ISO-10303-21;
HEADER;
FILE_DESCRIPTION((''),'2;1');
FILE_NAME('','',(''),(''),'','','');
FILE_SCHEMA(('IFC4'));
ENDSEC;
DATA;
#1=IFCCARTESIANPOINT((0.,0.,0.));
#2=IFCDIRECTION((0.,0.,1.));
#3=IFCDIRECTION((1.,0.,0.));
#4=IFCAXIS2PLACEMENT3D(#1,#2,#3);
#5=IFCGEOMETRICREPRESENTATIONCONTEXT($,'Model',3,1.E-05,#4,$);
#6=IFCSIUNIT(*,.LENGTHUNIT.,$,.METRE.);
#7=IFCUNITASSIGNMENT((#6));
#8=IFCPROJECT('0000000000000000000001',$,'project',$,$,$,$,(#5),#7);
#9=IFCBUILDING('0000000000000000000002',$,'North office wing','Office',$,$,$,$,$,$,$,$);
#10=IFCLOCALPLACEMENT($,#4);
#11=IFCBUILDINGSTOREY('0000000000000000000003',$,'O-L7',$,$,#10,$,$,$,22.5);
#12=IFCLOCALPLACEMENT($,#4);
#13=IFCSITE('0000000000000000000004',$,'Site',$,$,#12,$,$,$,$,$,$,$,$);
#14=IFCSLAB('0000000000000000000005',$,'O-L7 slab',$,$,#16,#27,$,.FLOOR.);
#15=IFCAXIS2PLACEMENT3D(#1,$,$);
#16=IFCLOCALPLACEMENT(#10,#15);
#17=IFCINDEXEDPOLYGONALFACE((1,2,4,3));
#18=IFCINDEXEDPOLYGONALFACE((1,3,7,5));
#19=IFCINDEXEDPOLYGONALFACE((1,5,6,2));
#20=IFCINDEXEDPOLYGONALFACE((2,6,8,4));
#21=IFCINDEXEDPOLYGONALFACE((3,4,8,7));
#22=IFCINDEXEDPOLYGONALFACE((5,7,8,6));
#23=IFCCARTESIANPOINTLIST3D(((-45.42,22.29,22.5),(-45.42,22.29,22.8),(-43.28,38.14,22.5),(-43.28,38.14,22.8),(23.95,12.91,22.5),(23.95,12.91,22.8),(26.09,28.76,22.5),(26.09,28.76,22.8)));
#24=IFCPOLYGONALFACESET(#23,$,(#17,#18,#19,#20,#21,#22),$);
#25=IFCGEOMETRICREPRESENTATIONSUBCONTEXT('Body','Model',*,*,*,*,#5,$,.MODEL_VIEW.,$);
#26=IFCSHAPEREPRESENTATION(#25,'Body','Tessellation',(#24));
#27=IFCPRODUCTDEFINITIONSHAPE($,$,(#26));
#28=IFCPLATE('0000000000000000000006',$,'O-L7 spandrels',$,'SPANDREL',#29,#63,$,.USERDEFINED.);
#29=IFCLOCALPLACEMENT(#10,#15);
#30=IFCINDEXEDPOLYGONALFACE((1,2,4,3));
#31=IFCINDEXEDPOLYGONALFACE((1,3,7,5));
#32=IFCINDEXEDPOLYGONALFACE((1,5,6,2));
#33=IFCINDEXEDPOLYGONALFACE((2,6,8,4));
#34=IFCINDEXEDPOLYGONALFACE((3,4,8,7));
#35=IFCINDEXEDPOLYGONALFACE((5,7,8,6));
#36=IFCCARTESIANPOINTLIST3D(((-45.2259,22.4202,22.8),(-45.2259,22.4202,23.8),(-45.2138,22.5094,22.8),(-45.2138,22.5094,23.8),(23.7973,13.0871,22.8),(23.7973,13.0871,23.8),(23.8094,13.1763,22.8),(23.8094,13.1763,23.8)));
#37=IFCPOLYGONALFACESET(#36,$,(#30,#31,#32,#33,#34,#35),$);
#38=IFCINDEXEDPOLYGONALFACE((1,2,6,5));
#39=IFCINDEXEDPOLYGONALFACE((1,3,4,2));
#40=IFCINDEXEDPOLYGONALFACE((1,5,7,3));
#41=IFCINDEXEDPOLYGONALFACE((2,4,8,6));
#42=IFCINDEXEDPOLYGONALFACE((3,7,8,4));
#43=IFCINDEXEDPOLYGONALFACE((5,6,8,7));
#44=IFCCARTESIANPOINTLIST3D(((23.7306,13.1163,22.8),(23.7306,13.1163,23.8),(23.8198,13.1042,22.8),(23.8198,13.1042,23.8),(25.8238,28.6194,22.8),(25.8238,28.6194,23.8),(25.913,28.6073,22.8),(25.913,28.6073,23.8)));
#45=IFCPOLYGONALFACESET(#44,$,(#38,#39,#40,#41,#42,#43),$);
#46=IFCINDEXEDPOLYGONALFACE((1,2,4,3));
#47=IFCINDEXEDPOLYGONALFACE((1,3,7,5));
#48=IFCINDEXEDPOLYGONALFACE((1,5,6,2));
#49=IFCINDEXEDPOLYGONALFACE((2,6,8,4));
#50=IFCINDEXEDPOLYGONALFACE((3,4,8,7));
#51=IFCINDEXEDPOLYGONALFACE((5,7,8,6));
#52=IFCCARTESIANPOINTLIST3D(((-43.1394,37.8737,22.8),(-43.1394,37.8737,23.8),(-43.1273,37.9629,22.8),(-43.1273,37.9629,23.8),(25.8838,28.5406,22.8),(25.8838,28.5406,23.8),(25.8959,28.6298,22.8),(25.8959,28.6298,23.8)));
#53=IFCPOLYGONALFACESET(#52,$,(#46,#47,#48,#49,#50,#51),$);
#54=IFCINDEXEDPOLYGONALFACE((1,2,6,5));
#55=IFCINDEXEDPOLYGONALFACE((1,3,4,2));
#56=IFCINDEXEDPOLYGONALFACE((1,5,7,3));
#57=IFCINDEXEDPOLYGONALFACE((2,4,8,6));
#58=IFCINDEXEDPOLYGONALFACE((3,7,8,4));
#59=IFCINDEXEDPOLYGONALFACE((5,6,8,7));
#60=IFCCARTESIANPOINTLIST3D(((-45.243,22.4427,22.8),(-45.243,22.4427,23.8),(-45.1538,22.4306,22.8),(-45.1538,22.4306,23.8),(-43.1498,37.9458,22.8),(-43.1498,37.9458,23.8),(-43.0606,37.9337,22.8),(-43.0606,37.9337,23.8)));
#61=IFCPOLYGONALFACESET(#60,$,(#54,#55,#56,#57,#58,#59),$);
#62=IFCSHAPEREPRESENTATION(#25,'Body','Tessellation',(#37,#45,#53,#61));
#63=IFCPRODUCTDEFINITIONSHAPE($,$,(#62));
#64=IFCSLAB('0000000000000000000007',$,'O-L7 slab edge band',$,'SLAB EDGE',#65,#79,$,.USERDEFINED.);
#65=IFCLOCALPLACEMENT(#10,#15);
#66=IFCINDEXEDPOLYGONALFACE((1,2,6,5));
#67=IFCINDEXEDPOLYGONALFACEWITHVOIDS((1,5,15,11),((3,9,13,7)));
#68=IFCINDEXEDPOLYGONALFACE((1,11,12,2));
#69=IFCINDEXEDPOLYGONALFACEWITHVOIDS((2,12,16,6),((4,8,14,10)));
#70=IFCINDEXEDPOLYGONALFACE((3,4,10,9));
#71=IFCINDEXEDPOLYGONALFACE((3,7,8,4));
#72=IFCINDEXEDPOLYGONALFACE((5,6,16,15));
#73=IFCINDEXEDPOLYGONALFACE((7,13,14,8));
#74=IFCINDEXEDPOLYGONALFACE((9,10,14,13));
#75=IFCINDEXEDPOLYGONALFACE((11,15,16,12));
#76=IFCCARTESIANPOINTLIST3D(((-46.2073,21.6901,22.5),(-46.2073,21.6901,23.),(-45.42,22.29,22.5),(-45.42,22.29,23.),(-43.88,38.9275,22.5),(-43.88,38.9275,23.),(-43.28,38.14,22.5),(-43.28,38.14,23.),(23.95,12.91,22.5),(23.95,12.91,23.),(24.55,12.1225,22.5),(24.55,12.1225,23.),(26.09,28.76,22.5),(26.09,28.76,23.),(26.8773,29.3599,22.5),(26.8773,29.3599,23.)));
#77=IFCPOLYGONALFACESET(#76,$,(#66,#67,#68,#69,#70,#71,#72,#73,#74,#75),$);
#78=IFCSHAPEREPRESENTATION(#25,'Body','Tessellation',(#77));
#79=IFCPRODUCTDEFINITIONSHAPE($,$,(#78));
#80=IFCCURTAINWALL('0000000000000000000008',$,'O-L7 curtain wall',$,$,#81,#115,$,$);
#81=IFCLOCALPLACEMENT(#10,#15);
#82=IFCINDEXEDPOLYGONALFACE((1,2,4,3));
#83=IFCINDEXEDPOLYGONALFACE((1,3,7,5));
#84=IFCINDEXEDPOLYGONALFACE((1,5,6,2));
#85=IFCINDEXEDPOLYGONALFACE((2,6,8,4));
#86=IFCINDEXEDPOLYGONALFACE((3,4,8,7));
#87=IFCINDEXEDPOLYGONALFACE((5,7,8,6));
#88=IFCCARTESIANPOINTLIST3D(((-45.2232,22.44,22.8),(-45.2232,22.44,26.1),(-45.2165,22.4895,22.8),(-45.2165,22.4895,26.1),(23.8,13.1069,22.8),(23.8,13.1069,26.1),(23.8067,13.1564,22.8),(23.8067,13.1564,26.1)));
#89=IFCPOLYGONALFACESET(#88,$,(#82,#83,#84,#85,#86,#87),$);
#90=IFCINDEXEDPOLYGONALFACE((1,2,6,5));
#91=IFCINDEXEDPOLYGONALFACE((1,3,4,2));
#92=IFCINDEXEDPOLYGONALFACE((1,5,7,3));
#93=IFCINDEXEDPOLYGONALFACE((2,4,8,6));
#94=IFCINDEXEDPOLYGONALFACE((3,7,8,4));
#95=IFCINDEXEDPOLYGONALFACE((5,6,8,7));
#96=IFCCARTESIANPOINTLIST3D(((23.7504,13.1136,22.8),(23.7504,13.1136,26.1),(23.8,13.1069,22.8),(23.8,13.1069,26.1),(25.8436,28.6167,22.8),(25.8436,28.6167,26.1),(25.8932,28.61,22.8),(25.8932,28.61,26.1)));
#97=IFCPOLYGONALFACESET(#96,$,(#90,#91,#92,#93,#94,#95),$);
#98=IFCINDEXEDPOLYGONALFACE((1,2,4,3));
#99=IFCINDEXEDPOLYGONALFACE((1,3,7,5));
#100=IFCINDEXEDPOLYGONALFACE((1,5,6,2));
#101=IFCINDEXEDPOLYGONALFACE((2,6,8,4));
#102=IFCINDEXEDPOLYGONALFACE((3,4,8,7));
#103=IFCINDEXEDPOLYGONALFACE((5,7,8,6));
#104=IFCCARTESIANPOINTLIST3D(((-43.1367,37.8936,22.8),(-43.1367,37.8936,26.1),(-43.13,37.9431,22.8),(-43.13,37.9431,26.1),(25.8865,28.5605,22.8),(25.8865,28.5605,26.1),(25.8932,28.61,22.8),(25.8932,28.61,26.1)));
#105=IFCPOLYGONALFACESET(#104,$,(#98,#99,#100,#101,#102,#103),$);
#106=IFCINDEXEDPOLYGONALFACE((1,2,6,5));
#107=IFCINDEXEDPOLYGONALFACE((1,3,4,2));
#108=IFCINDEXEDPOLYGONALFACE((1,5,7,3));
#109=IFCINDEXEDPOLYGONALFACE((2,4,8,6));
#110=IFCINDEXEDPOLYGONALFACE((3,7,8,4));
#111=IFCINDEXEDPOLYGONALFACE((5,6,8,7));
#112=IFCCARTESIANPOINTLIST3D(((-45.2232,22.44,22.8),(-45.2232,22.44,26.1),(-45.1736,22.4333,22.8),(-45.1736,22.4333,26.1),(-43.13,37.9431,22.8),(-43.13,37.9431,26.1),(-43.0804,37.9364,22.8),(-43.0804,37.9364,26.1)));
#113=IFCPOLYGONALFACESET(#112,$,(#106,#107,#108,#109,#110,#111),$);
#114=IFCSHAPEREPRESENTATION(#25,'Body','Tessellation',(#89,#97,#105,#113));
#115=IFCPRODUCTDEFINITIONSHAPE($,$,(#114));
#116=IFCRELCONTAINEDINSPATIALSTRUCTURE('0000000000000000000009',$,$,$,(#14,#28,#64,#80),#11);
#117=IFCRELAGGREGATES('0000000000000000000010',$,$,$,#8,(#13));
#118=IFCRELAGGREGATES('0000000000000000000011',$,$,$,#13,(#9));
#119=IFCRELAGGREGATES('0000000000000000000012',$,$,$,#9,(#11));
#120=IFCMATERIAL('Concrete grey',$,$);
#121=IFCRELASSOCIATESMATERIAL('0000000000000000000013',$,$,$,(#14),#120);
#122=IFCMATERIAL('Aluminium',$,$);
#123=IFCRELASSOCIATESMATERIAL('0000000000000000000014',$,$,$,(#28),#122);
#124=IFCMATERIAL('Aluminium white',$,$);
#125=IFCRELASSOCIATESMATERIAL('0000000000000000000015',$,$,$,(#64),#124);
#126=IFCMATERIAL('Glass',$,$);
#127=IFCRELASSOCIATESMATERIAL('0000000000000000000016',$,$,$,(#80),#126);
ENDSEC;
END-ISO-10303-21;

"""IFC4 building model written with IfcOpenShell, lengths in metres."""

from ifc_helpers import new_model, si_unit, frame, origin_with_axes, place, context, subcontext, project, spatial, polyline, outline, extrude, material, element, save


model = new_model("IFC4")

# Units and contexts
model_context = context("Model", 3, precision=1e-05, world=origin_with_axes())
body_context = subcontext(model_context, "Body", "Model", "MODEL_VIEW")
ifc_project = project(units=[si_unit("LENGTHUNIT", "METRE")], contexts=[model_context])

# Site, building, storey
site_placement = place(None, origin_with_axes())
site = spatial("IfcSite", under=ifc_project, at=site_placement, Name="Site")
building = spatial("IfcBuilding", under=site, Name="North office wing", Description="Office")
storey_placement = place(None, origin_with_axes())
storey = spatial("IfcBuildingStorey", under=building, at=storey_placement, Name="O-L7", Elevation=22.5)

# Shared definitions
ifc_material_1 = material(Name="Aluminium")

# Slab
ifc_material_2 = material(Name="Concrete grey")
slab_1_placement = place(storey_placement, origin_with_axes())
element("IfcSlab", 1, at=slab_1_placement, inside=storey, material=ifc_material_2, Name="O-L7 slab", PredefinedType="FLOOR", context=body_context, shape_type="SweptSolid", body=[
    extrude(outline(polyline([(-45.42, 22.29), (23.95, 12.91), (26.09, 28.76), (-43.28, 38.14), (-45.42, 22.29)])), frame((0.0, 0.0, 22.5), z_axis=(0.0, 0.0, 1.0), x_axis=(1.0, 0.0, 0.0)), (0.0, 0.0, 1.0), 0.3),
])

# Plate
plate_placement = place(storey_placement, origin_with_axes())
element("IfcPlate", 2, at=plate_placement, inside=storey, material=ifc_material_1, Name="O-L7 spandrels", ObjectType="SPANDREL", PredefinedType="USERDEFINED", context=body_context, shape_type="SweptSolid", body=[
    extrude(outline(polyline([(-45.2259, 22.4202), (23.7973, 13.0871), (23.8094, 13.1763), (-45.2138, 22.5094), (-45.2259, 22.4202)])), frame((0.0, 0.0, 22.8), z_axis=(0.0, 0.0, 1.0), x_axis=(1.0, 0.0, 0.0)), (0.0, 0.0, 1.0), 1.0),
    extrude(outline(polyline([(23.8198, 13.1042), (25.913, 28.6073), (25.8238, 28.6194), (23.7306, 13.1163), (23.8198, 13.1042)])), frame((0.0, 0.0, 22.8), z_axis=(0.0, 0.0, 1.0), x_axis=(1.0, 0.0, 0.0)), (0.0, 0.0, 1.0), 1.0),
    extrude(outline(polyline([(25.8959, 28.6298), (-43.1273, 37.9629), (-43.1394, 37.8737), (25.8838, 28.5406), (25.8959, 28.6298)])), frame((0.0, 0.0, 22.8), z_axis=(0.0, 0.0, 1.0), x_axis=(1.0, 0.0, 0.0)), (0.0, 0.0, 1.0), 1.0),
    extrude(outline(polyline([(-43.1498, 37.9458), (-45.243, 22.4427), (-45.1538, 22.4306), (-43.0606, 37.9337), (-43.1498, 37.9458)])), frame((0.0, 0.0, 22.8), z_axis=(0.0, 0.0, 1.0), x_axis=(1.0, 0.0, 0.0)), (0.0, 0.0, 1.0), 1.0),
])

# Slab
ifc_material_3 = material(Name="Aluminium white")
slab_2_placement = place(storey_placement, origin_with_axes())
element("IfcSlab", 3, at=slab_2_placement, inside=storey, material=ifc_material_3, Name="O-L7 slab edge band", ObjectType="SLAB EDGE", PredefinedType="USERDEFINED", context=body_context, shape_type="SweptSolid", body=[
    extrude(outline(polyline([(-46.2073, 21.6901), (24.55, 12.1225), (26.8773, 29.3599), (-43.88, 38.9275), (-46.2073, 21.6901)]), holes=[polyline([(-45.42, 22.29), (23.95, 12.91), (26.09, 28.76), (-43.28, 38.14), (-45.42, 22.29)])]), frame((0.0, 0.0, 22.5), z_axis=(0.0, 0.0, 1.0), x_axis=(1.0, 0.0, 0.0)), (0.0, 0.0, 1.0), 0.5),
])

# Curtain wall
ifc_material_4 = material(Name="Glass")
curtain_wall_placement = place(storey_placement, origin_with_axes())
element("IfcCurtainWall", 4, at=curtain_wall_placement, inside=storey, material=ifc_material_4, Name="O-L7 curtain wall", context=body_context, shape_type="SweptSolid", body=[
    extrude(outline(polyline([(-45.2232, 22.44), (23.8, 13.1069), (23.8067, 13.1564), (-45.2165, 22.4895), (-45.2232, 22.44)])), frame((0.0, 0.0, 22.8), z_axis=(0.0, 0.0, 1.0), x_axis=(1.0, 0.0, 0.0)), (0.0, 0.0, 1.0), 3.3),
    extrude(outline(polyline([(23.8, 13.1069), (25.8932, 28.61), (25.8436, 28.6167), (23.7504, 13.1136), (23.8, 13.1069)])), frame((0.0, 0.0, 22.8), z_axis=(0.0, 0.0, 1.0), x_axis=(1.0, 0.0, 0.0)), (0.0, 0.0, 1.0), 3.3),
    extrude(outline(polyline([(25.8932, 28.61), (-43.13, 37.9431), (-43.1367, 37.8936), (25.8865, 28.5605), (25.8932, 28.61)])), frame((0.0, 0.0, 22.8), z_axis=(0.0, 0.0, 1.0), x_axis=(1.0, 0.0, 0.0)), (0.0, 0.0, 1.0), 3.3),
    extrude(outline(polyline([(-43.13, 37.9431), (-45.2232, 22.44), (-45.1736, 22.4333), (-43.0804, 37.9364), (-43.13, 37.9431)])), frame((0.0, 0.0, 22.8), z_axis=(0.0, 0.0, 1.0), x_axis=(1.0, 0.0, 0.0)), (0.0, 0.0, 1.0), 3.3),
])

save(model, "model.ifc")
